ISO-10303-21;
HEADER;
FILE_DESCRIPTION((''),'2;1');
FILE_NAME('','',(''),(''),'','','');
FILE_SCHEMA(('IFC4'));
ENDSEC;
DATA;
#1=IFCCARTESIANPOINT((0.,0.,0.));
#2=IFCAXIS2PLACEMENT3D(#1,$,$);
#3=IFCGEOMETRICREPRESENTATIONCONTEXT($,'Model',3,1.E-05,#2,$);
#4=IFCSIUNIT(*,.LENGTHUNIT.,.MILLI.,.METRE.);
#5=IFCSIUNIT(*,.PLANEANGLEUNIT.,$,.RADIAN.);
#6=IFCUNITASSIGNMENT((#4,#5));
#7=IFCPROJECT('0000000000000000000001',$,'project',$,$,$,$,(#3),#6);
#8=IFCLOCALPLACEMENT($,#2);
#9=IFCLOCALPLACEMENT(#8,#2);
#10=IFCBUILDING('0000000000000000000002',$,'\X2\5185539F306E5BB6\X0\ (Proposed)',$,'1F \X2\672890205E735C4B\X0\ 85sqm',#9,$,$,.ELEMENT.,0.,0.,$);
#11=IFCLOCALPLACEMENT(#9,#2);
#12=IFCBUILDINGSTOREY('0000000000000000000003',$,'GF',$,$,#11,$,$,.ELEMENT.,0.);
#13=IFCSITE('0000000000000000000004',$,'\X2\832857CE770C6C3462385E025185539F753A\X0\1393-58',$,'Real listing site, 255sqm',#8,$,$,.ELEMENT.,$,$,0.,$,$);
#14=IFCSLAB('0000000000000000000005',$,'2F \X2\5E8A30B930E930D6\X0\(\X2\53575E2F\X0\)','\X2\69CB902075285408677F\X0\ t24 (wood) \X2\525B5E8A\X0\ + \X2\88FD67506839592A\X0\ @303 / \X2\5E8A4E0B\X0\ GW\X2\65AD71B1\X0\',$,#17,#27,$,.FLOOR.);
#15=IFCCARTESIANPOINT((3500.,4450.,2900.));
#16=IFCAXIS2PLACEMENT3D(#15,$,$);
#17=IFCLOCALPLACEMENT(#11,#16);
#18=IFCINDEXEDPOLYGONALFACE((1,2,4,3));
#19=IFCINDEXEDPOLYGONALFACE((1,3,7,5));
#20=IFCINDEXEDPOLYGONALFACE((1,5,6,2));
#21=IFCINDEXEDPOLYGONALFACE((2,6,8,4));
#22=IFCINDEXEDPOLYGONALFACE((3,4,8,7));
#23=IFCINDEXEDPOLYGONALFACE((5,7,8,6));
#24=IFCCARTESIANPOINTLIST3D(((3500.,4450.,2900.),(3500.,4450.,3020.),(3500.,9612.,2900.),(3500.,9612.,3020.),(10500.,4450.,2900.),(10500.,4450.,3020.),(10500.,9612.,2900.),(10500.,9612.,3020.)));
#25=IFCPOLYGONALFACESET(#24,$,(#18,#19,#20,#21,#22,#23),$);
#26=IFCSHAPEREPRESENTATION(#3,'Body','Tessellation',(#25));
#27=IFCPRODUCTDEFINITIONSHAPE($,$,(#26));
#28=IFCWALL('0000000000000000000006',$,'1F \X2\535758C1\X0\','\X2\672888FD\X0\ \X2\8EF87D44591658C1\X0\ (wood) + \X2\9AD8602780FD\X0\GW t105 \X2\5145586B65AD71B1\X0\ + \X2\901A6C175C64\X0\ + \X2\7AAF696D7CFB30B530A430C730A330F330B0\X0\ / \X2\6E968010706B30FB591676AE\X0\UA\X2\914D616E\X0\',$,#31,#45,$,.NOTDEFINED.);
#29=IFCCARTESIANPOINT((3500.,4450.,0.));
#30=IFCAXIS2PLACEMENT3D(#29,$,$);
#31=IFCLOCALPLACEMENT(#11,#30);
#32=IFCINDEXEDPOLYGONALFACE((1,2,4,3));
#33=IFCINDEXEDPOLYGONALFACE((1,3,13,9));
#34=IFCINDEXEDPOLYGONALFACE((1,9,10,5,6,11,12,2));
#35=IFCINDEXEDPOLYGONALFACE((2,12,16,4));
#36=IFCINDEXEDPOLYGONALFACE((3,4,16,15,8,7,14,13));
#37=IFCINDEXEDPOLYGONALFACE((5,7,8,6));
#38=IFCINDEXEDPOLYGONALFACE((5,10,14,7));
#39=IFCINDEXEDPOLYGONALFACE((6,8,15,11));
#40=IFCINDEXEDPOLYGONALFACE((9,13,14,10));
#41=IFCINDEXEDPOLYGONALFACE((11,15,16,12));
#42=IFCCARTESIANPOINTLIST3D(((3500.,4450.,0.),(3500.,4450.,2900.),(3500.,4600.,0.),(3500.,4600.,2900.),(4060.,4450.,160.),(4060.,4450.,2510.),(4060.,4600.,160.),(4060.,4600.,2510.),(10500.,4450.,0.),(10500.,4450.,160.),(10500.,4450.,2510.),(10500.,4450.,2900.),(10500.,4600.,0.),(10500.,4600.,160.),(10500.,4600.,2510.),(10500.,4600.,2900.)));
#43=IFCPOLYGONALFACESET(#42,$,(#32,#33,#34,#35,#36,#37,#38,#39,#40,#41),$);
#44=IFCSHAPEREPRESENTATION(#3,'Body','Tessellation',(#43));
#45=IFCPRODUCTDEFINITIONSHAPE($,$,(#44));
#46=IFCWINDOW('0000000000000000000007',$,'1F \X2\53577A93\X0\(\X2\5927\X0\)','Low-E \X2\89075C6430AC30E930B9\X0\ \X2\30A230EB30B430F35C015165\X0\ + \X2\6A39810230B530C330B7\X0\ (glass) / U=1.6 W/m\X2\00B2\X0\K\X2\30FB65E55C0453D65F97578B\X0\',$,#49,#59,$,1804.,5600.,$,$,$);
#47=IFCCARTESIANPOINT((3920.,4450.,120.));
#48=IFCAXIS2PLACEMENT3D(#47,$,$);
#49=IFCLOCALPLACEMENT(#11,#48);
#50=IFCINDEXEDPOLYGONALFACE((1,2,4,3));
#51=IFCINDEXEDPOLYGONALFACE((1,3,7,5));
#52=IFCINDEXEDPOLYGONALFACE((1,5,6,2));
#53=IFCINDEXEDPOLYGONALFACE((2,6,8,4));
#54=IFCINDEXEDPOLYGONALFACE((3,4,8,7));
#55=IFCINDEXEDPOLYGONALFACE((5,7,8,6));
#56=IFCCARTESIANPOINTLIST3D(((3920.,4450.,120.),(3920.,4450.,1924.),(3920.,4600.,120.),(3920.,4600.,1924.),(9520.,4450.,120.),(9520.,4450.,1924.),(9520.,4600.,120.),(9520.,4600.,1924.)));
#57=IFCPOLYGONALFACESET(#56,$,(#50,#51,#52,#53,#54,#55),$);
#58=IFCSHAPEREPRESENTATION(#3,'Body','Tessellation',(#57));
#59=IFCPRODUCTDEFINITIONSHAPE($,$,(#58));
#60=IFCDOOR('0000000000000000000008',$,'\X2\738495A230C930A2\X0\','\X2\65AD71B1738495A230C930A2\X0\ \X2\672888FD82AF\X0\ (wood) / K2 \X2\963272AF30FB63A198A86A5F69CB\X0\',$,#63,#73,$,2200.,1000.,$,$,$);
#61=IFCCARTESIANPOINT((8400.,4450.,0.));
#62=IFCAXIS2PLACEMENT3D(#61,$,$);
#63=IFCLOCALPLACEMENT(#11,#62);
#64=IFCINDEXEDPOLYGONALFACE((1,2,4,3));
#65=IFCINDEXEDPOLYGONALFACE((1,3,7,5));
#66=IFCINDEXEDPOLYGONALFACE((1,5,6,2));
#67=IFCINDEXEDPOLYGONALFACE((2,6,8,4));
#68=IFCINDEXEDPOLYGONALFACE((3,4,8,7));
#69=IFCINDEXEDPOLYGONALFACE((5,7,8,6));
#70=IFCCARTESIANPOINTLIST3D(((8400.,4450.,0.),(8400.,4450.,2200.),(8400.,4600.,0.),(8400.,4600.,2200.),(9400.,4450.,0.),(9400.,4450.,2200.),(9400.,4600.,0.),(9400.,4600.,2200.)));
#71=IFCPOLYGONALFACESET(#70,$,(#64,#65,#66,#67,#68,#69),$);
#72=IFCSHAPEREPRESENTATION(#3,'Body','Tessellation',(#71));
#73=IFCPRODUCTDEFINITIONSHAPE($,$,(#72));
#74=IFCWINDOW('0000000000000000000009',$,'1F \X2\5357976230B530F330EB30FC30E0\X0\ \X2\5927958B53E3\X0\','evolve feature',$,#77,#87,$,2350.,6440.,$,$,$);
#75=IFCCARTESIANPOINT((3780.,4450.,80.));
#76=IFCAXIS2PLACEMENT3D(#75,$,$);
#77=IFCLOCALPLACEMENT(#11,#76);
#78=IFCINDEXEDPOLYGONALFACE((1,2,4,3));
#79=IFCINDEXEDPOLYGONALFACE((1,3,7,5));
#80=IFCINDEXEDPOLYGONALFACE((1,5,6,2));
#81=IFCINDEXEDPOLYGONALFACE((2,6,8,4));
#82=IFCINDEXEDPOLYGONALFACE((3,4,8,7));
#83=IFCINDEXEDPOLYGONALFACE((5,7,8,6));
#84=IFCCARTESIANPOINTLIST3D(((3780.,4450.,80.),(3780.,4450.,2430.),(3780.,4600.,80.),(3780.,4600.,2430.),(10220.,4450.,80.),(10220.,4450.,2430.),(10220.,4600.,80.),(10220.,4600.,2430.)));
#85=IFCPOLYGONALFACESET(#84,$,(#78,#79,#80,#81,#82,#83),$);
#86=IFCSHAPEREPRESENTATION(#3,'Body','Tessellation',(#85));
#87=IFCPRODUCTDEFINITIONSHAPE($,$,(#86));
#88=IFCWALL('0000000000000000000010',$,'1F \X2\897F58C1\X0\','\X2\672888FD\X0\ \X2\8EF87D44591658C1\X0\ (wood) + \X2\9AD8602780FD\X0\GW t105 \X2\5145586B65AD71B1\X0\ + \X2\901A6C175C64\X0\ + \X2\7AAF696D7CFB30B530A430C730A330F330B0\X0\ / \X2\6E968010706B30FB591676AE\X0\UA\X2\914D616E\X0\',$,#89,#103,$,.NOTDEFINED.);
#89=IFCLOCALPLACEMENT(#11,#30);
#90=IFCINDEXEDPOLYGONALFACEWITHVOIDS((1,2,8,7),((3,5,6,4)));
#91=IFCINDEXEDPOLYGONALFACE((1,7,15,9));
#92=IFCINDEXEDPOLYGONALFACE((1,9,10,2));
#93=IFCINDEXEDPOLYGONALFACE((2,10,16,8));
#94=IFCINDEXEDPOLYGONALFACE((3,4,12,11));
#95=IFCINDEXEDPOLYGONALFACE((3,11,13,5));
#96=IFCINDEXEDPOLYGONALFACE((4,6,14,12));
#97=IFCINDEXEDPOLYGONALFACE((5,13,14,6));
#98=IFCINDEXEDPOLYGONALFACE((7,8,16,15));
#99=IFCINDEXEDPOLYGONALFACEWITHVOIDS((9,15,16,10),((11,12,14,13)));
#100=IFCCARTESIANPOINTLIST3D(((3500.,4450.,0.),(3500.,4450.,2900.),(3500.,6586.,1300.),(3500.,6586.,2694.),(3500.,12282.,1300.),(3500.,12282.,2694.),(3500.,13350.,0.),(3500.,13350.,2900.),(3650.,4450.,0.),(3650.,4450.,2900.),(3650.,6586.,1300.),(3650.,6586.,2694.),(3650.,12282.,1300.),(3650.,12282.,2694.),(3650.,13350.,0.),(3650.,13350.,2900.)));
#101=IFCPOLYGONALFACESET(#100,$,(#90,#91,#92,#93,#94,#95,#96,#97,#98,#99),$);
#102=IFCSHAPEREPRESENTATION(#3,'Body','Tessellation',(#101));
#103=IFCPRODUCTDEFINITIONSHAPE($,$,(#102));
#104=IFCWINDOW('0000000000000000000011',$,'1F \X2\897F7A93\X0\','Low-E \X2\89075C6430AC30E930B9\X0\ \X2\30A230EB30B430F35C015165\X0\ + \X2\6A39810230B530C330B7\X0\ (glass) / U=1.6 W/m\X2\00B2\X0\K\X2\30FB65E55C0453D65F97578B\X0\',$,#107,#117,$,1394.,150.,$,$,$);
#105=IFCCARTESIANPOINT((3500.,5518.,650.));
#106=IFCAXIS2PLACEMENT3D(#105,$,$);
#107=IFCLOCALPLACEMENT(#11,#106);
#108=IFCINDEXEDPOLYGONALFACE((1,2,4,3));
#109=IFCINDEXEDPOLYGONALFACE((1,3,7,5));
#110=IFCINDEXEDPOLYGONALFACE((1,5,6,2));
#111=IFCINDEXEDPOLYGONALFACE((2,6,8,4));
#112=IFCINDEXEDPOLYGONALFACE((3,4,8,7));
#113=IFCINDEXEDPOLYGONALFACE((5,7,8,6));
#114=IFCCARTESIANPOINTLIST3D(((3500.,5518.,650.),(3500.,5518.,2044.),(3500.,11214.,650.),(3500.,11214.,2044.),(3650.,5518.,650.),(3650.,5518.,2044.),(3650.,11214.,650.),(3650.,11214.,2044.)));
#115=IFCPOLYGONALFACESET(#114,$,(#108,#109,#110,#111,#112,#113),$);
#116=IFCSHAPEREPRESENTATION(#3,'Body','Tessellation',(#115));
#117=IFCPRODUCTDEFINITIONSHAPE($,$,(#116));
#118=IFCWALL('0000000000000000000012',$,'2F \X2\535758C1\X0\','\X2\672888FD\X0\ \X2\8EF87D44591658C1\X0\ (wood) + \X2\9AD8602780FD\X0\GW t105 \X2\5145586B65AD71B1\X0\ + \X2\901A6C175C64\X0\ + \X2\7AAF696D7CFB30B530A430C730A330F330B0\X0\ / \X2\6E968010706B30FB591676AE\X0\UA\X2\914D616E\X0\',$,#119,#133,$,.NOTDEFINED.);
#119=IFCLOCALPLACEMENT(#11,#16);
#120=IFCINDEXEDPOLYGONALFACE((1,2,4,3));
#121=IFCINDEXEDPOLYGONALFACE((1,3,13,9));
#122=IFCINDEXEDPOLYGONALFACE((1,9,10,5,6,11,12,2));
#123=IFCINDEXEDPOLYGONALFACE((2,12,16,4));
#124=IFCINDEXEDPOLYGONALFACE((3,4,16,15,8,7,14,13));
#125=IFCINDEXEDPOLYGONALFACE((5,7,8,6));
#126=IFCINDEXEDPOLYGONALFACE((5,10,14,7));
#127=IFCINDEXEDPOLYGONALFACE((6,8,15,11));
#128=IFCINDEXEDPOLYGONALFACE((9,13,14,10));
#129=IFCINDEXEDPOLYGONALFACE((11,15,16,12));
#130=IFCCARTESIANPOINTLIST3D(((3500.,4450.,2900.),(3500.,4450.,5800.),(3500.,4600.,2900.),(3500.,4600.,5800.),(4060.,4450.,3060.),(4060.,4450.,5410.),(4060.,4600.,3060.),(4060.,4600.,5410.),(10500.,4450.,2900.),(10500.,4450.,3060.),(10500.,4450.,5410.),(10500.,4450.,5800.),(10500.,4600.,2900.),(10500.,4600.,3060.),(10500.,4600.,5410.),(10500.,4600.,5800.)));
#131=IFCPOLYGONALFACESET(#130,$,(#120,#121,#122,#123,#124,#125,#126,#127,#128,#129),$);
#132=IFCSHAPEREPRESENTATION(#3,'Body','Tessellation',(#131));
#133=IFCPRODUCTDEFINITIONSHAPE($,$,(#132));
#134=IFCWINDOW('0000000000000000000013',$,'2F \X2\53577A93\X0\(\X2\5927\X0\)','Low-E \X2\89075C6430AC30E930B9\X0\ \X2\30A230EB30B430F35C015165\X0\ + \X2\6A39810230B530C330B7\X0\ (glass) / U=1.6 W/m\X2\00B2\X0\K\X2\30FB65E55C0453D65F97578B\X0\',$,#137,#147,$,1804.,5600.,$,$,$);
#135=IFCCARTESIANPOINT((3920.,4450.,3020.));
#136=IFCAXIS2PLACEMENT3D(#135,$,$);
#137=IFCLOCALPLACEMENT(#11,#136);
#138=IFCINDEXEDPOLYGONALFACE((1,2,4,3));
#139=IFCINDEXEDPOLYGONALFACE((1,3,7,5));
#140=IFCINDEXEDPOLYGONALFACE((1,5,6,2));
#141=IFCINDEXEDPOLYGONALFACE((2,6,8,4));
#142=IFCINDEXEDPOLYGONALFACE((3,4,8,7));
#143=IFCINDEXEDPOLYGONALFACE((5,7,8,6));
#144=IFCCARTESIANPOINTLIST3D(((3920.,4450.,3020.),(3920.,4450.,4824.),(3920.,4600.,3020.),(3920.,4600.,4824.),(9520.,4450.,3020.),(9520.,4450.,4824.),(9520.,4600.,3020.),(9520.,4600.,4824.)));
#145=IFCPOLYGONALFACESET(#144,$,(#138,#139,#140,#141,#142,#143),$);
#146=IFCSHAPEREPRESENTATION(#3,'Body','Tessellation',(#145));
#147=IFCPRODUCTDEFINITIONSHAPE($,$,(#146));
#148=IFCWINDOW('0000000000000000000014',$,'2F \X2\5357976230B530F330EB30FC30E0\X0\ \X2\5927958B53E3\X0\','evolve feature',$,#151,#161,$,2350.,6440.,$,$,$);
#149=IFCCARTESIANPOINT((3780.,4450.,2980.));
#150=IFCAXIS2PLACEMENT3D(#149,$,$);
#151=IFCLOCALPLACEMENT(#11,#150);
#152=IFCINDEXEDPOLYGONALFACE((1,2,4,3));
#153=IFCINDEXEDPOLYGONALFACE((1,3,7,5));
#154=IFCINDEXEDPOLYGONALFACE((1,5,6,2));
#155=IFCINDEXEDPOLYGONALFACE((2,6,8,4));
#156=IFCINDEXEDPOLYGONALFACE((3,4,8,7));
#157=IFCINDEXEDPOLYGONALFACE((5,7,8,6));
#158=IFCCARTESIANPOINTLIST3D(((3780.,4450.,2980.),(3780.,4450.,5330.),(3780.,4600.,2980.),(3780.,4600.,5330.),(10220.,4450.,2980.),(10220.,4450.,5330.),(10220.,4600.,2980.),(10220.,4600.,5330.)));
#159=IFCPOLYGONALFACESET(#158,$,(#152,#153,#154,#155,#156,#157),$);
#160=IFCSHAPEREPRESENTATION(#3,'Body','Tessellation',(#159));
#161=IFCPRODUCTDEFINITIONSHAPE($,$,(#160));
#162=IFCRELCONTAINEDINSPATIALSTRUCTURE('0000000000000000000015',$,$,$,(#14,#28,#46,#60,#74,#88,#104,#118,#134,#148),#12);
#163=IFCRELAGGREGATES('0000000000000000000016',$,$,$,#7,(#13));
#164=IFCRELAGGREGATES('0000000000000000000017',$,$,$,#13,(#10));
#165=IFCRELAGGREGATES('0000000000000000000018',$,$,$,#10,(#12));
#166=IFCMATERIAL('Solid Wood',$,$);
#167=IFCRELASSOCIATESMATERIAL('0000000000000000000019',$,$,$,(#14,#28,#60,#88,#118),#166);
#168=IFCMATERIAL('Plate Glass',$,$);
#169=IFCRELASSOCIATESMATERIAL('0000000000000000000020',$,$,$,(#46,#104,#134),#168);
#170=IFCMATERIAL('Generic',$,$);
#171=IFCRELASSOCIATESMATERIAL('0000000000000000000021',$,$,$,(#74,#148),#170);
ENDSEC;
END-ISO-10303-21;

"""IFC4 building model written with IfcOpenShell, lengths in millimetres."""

from ifc_helpers import new_model, si_unit, frame, frame_2d, origin, place, context, project, spatial, rectangle, extrude, material, element, fill, save


model = new_model("IFC4")

# Units and contexts
model_context = context("Model", 3, precision=1e-05, world=origin())
ifc_project = project(units=[si_unit("LENGTHUNIT", "METRE", prefix="MILLI"), si_unit("PLANEANGLEUNIT", "RADIAN")], contexts=[model_context])

# Site, building, storey
site_placement = place(None, origin())
site = spatial("IfcSite", under=ifc_project, at=site_placement, Name="茨城県水戸市内原町1393-58", ObjectType="Real listing site, 255sqm", CompositionType="ELEMENT", RefElevation=0.0)
building_placement = place(site_placement, origin())
building = spatial("IfcBuilding", under=site, at=building_placement, Name="内原の家 (Proposed)", ObjectType="1F 木造平屋 85sqm", CompositionType="ELEMENT", ElevationOfRefHeight=0.0, ElevationOfTerrain=0.0)
storey_placement = place(building_placement, origin())
storey = spatial("IfcBuildingStorey", under=building, at=storey_placement, Name="GF", CompositionType="ELEMENT", Elevation=0.0)

# Slab
ifc_material_1 = material(Name="Solid Wood")
slab_1_placement = place(storey_placement, frame((3500.0, 4450.0, 2900.0)))
element("IfcSlab", 1, at=slab_1_placement, inside=storey, material=ifc_material_1, Name="2F 床スラブ(南帯)", Description="構造用合板 t24 (wood) 剛床 + 製材根太 @303 / 床下 GW断熱", PredefinedType="FLOOR", context=model_context, shape_type="SweptSolid", body=[
    extrude(rectangle(XDim=7000.0, YDim=5162.0, at=frame_2d((3500.0, 2581.0))), frame((3500.0, 4450.0, 2900.0)), (0.0, 0.0, 1.0), 120.0),
])
ifc_material_2 = material(Name="Generic")

# Wall, openings, windows, door
wall_1_placement = place(storey_placement, frame((3500.0, 4450.0, 0.0)))
wall_1 = element("IfcWall", 2, at=wall_1_placement, inside=storey, material=ifc_material_1, Name="1F 南壁", Description="木製 軸組外壁 (wood) + 高性能GW t105 充填断熱 + 通気層 + 窯業系サイディング / 準耐火・外皮UA配慮", PredefinedType="NOTDEFINED", context=model_context, shape_type="SweptSolid", body=[
    extrude(rectangle(XDim=7000.0, YDim=150.0, at=frame_2d((3500.0, 75.0))), frame((3500.0, 4450.0, 0.0)), (0.0, 0.0, 1.0), 2900.0),
])
opening_1_placement = place(storey_placement, frame((3920.0, 4450.0, 120.0)))
opening_1 = element("IfcOpeningElement", 3, at=opening_1_placement, cuts=wall_1, PredefinedType="NOTDEFINED", context=model_context, shape_type="SweptSolid", body=[
    extrude(rectangle(XDim=5600.0, YDim=150.0, at=frame_2d((2800.0, 75.0))), frame((3920.0, 4450.0, 120.0)), (0.0, 0.0, 1.0), 1804.0),
])
opening_2_placement = place(storey_placement, frame((8400.0, 4450.0, 0.0)))
opening_2 = element("IfcOpeningElement", 4, at=opening_2_placement, cuts=wall_1, PredefinedType="NOTDEFINED", context=model_context, shape_type="SweptSolid", body=[
    extrude(rectangle(XDim=1000.0, YDim=150.0, at=frame_2d((500.0, 75.0))), frame((8400.0, 4450.0, 0.0)), (0.0, 0.0, 1.0), 2200.0),
])
opening_3_placement = place(storey_placement, frame((3780.0, 4450.0, 80.0)))
opening_3 = element("IfcOpeningElement", 5, at=opening_3_placement, cuts=wall_1, PredefinedType="NOTDEFINED", context=model_context, shape_type="SweptSolid", body=[
    extrude(rectangle(XDim=6440.0, YDim=150.0, at=frame_2d((3220.0, 75.0))), frame((3780.0, 4450.0, 80.0)), (0.0, 0.0, 1.0), 2350.0),
])
ifc_material_3 = material(Name="Plate Glass")
window_1_placement = place(storey_placement, frame((3920.0, 4450.0, 120.0)))
window_1 = element("IfcWindow", 6, at=window_1_placement, inside=storey, material=ifc_material_3, Name="1F 南窓(大)", Description="Low-E 複層ガラス アルゴン封入 + 樹脂サッシ (glass) / U=1.6 W/m²K・日射取得型", OverallHeight=1804.0, OverallWidth=5600.0, context=model_context, shape_type="SweptSolid", body=[
    extrude(rectangle(XDim=5600.0, YDim=150.0, at=frame_2d((2800.0, 75.0))), frame((3920.0, 4450.0, 120.0)), (0.0, 0.0, 1.0), 1804.0),
])
fill(opening_1, window_1)
door_placement = place(storey_placement, frame((8400.0, 4450.0, 0.0)))
door = element("IfcDoor", 7, at=door_placement, inside=storey, material=ifc_material_1, Name="玄関ドア", Description="断熱玄関ドア 木製芯 (wood) / K2 防犯・採風機構", OverallHeight=2200.0, OverallWidth=1000.0, context=model_context, shape_type="SweptSolid", body=[
    extrude(rectangle(XDim=1000.0, YDim=150.0, at=frame_2d((500.0, 75.0))), frame((8400.0, 4450.0, 0.0)), (0.0, 0.0, 1.0), 2200.0),
])
fill(opening_2, door)
window_2_placement = place(storey_placement, frame((3780.0, 4450.0, 80.0)))
window_2 = element("IfcWindow", 8, at=window_2_placement, inside=storey, material=ifc_material_2, Name="1F 南面サンルーム 大開口", Description="evolve feature", OverallHeight=2350.0, OverallWidth=6440.0, context=model_context, shape_type="SweptSolid", body=[
    extrude(rectangle(XDim=6440.0, YDim=150.0, at=frame_2d((3220.0, 75.0))), frame((3780.0, 4450.0, 80.0)), (0.0, 0.0, 1.0), 2350.0),
])
fill(opening_3, window_2)

# Wall, opening, window
wall_2_placement = place(storey_placement, frame((3500.0, 4450.0, 0.0)))
wall_2 = element("IfcWall", 9, at=wall_2_placement, inside=storey, material=ifc_material_1, Name="1F 西壁", Description="木製 軸組外壁 (wood) + 高性能GW t105 充填断熱 + 通気層 + 窯業系サイディング / 準耐火・外皮UA配慮", PredefinedType="NOTDEFINED", context=model_context, shape_type="SweptSolid", body=[
    extrude(rectangle(XDim=150.0, YDim=8900.0, at=frame_2d((75.0, 4450.0))), frame((3500.0, 4450.0, 0.0)), (0.0, 0.0, 1.0), 2900.0),
])
opening_4_placement = place(storey_placement, frame((3500.0, 5518.0, 650.0)))
opening_4 = element("IfcOpeningElement", 10, at=opening_4_placement, cuts=wall_2, PredefinedType="NOTDEFINED", context=model_context, shape_type="SweptSolid", body=[
    extrude(rectangle(XDim=150.0, YDim=5696.0, at=frame_2d((75.0, 2848.0))), frame((3500.0, 5518.0, 650.0)), (0.0, 0.0, 1.0), 1394.0),
])
window_3_placement = place(storey_placement, frame((3500.0, 5518.0, 650.0)))
window_3 = element("IfcWindow", 11, at=window_3_placement, inside=storey, material=ifc_material_3, Name="1F 西窓", Description="Low-E 複層ガラス アルゴン封入 + 樹脂サッシ (glass) / U=1.6 W/m²K・日射取得型", OverallHeight=1394.0, OverallWidth=150.0, context=model_context, shape_type="SweptSolid", body=[
    extrude(rectangle(XDim=150.0, YDim=5696.0, at=frame_2d((75.0, 2848.0))), frame((3500.0, 5518.0, 650.0)), (0.0, 0.0, 1.0), 1394.0),
])
fill(opening_4, window_3)

# Wall, openings, windows
wall_3_placement = place(storey_placement, frame((3500.0, 4450.0, 2900.0)))
wall_3 = element("IfcWall", 12, at=wall_3_placement, inside=storey, material=ifc_material_1, Name="2F 南壁", Description="木製 軸組外壁 (wood) + 高性能GW t105 充填断熱 + 通気層 + 窯業系サイディング / 準耐火・外皮UA配慮", PredefinedType="NOTDEFINED", context=model_context, shape_type="SweptSolid", body=[
    extrude(rectangle(XDim=7000.0, YDim=150.0, at=frame_2d((3500.0, 75.0))), frame((3500.0, 4450.0, 2900.0)), (0.0, 0.0, 1.0), 2900.0),
])
opening_5_placement = place(storey_placement, frame((3920.0, 4450.0, 3020.0)))
opening_5 = element("IfcOpeningElement", 13, at=opening_5_placement, cuts=wall_3, PredefinedType="NOTDEFINED", context=model_context, shape_type="SweptSolid", body=[
    extrude(rectangle(XDim=5600.0, YDim=150.0, at=frame_2d((2800.0, 75.0))), frame((3920.0, 4450.0, 3020.0)), (0.0, 0.0, 1.0), 1804.0),
])
opening_6_placement = place(storey_placement, frame((3780.0, 4450.0, 2980.0)))
opening_6 = element("IfcOpeningElement", 14, at=opening_6_placement, cuts=wall_3, PredefinedType="NOTDEFINED", context=model_context, shape_type="SweptSolid", body=[
    extrude(rectangle(XDim=6440.0, YDim=150.0, at=frame_2d((3220.0, 75.0))), frame((3780.0, 4450.0, 2980.0)), (0.0, 0.0, 1.0), 2350.0),
])
window_4_placement = place(storey_placement, frame((3920.0, 4450.0, 3020.0)))
window_4 = element("IfcWindow", 15, at=window_4_placement, inside=storey, material=ifc_material_3, Name="2F 南窓(大)", Description="Low-E 複層ガラス アルゴン封入 + 樹脂サッシ (glass) / U=1.6 W/m²K・日射取得型", OverallHeight=1804.0, OverallWidth=5600.0, context=model_context, shape_type="SweptSolid", body=[
    extrude(rectangle(XDim=5600.0, YDim=150.0, at=frame_2d((2800.0, 75.0))), frame((3920.0, 4450.0, 3020.0)), (0.0, 0.0, 1.0), 1804.0),
])
fill(opening_5, window_4)
window_5_placement = place(storey_placement, frame((3780.0, 4450.0, 2980.0)))
window_5 = element("IfcWindow", 16, at=window_5_placement, inside=storey, material=ifc_material_2, Name="2F 南面サンルーム 大開口", Description="evolve feature", OverallHeight=2350.0, OverallWidth=6440.0, context=model_context, shape_type="SweptSolid", body=[
    extrude(rectangle(XDim=6440.0, YDim=150.0, at=frame_2d((3220.0, 75.0))), frame((3780.0, 4450.0, 2980.0)), (0.0, 0.0, 1.0), 2350.0),
])
fill(opening_6, window_5)

save(model, "model.ifc")
